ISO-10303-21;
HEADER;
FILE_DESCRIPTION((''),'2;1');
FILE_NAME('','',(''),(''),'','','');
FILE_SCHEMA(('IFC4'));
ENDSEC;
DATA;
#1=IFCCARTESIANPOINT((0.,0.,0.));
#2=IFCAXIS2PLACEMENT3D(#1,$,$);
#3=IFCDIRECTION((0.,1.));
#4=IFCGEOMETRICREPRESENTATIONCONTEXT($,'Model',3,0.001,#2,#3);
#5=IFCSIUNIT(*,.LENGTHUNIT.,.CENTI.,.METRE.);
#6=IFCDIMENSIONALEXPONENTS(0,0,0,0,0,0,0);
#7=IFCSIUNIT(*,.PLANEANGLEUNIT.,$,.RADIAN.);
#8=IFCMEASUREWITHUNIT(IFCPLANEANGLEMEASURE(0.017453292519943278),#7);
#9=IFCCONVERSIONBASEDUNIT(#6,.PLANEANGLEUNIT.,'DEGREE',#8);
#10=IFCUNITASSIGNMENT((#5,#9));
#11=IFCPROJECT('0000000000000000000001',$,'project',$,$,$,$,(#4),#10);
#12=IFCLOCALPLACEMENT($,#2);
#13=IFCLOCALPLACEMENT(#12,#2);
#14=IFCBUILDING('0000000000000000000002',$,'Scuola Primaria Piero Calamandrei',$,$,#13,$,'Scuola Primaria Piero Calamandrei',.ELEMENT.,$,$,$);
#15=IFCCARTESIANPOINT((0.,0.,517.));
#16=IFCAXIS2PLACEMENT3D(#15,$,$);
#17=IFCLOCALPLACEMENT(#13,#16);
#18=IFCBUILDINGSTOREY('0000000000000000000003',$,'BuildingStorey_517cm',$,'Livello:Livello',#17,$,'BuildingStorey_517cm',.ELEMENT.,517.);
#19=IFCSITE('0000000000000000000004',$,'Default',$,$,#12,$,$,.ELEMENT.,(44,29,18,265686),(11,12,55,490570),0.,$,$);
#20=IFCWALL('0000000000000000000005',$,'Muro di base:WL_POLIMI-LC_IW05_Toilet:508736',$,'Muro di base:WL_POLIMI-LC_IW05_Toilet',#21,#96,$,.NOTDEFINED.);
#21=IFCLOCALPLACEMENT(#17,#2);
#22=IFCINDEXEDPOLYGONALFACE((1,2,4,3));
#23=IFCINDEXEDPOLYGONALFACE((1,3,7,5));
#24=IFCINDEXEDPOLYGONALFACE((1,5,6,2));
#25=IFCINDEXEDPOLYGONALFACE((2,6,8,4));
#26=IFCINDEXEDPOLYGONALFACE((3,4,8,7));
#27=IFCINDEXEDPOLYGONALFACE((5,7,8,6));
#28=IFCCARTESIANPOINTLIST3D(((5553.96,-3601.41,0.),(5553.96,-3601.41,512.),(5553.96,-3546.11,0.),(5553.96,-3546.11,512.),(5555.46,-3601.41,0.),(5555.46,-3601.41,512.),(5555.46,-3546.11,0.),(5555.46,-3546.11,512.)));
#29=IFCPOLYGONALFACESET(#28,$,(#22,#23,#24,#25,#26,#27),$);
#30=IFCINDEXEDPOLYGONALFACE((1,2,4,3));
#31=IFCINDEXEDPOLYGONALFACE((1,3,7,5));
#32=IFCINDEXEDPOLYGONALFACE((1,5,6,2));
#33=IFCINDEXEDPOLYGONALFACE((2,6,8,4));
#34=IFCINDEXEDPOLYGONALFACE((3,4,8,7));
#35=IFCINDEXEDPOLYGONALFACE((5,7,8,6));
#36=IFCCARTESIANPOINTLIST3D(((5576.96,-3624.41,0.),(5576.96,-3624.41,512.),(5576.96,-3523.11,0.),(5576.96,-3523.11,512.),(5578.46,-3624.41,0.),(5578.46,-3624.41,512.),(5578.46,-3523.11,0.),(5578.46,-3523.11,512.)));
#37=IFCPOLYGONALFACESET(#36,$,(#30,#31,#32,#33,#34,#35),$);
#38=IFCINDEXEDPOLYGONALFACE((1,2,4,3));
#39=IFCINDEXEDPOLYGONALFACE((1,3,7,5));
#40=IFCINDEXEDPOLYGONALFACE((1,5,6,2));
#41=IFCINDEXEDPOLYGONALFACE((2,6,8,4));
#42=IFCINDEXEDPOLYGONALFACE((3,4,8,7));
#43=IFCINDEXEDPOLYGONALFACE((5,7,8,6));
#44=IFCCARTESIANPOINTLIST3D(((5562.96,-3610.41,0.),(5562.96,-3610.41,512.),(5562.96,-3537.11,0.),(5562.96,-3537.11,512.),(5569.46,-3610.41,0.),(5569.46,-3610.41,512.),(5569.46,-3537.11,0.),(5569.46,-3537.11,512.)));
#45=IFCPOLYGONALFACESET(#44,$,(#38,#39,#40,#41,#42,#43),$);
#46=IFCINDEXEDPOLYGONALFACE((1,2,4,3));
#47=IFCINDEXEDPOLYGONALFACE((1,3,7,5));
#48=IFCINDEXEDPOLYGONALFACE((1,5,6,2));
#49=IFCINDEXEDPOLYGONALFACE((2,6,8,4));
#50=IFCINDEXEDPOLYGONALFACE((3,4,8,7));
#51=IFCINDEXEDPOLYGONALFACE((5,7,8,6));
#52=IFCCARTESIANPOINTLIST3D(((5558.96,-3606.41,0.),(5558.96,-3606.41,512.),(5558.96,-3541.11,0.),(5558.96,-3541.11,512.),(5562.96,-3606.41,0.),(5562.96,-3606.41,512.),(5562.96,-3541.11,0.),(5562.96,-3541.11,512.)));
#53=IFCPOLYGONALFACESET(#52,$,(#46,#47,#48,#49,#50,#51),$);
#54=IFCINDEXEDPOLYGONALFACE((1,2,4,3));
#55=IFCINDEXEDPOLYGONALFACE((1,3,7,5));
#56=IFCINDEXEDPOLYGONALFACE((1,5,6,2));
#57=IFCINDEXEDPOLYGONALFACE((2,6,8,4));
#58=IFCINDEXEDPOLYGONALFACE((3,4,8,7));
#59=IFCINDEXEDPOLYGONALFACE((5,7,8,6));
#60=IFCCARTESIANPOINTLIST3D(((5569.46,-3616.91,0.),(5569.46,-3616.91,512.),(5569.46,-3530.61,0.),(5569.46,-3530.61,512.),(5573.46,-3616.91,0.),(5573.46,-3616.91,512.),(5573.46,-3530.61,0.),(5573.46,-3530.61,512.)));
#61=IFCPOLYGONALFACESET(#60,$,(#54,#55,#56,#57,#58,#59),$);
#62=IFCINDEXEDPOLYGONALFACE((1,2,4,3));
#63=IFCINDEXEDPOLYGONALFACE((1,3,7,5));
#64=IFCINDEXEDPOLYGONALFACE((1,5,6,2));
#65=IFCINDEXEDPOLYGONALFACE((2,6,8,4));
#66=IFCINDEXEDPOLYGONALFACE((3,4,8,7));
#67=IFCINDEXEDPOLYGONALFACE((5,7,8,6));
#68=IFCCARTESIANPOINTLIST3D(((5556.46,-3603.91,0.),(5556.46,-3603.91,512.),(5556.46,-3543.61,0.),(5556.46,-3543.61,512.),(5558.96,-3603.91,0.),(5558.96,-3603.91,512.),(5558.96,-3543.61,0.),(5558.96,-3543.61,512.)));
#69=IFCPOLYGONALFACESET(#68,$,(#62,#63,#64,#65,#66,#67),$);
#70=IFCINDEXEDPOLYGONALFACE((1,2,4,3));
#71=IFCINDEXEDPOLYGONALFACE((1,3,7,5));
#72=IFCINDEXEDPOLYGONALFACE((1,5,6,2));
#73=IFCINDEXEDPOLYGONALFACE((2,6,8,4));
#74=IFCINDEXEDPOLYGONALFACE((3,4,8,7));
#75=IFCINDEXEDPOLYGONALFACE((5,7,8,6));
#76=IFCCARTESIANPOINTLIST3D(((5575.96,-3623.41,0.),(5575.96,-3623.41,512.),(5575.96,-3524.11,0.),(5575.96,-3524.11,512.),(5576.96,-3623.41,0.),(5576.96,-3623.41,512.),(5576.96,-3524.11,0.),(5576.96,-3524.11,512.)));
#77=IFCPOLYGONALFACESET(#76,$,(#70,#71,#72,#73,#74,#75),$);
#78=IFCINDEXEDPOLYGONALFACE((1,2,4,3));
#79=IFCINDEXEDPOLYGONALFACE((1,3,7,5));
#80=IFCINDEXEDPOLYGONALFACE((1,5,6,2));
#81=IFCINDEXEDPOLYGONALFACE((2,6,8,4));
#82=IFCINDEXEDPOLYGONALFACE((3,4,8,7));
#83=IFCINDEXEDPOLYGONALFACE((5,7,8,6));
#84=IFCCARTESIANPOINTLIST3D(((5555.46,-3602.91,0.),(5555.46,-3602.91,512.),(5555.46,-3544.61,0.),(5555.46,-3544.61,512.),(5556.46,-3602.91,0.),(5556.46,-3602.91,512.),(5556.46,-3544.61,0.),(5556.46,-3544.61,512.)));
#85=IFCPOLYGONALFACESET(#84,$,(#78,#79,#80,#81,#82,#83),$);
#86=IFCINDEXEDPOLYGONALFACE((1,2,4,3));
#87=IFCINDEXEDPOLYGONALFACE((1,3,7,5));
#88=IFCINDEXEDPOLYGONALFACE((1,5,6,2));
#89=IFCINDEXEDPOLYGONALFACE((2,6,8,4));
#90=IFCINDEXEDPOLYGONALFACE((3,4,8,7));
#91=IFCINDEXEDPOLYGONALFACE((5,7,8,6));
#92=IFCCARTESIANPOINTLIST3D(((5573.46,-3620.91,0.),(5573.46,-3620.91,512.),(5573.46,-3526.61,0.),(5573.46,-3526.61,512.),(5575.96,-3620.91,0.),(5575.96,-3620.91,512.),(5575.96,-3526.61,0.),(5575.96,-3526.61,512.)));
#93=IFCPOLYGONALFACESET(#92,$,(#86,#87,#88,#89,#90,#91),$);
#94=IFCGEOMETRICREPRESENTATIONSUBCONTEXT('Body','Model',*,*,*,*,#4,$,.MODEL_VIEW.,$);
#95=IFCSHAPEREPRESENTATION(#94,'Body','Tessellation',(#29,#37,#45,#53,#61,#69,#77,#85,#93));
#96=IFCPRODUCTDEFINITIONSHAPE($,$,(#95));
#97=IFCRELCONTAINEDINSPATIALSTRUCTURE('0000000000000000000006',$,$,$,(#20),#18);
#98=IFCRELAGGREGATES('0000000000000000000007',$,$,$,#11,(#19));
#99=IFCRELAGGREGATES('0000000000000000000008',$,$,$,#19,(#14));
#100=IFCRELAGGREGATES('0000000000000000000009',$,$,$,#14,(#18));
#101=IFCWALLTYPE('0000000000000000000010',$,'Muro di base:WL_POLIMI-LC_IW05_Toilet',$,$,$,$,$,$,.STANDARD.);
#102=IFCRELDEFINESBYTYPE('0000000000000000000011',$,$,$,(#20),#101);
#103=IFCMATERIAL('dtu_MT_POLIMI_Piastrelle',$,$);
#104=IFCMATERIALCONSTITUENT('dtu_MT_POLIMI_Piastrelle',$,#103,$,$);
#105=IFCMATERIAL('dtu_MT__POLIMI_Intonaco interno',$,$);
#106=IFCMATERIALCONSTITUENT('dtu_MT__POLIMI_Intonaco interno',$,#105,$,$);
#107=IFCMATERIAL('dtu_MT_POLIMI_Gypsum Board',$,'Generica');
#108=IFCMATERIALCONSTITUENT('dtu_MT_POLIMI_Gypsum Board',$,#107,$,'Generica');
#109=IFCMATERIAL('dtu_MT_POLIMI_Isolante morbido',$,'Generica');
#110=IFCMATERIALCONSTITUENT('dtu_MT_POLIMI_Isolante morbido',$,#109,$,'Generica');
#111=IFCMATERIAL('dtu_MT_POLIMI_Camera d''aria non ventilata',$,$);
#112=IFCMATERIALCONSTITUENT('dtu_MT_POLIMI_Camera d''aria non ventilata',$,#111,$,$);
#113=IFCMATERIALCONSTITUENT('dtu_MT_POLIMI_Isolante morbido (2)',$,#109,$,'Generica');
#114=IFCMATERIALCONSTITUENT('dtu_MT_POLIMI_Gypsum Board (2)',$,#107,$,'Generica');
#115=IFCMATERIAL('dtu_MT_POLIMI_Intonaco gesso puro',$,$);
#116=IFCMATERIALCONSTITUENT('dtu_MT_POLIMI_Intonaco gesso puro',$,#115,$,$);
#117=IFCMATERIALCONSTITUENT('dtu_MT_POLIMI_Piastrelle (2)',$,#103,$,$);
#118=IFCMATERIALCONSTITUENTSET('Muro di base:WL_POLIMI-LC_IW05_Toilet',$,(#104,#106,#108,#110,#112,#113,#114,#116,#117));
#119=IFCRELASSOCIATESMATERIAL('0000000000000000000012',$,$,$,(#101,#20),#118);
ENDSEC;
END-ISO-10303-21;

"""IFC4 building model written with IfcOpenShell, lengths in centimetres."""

from ifc_helpers import new_model, entity, si_unit, converted_unit, direction, frame, origin, place, context, subcontext, project, spatial, indexed_curve, outline, extrude, material, constituent, constituent_set, type_object, element, save


model = new_model("IFC4")

# Units and contexts
model_context = context("Model", 3, precision=0.001, world=origin(), true_north=direction((0.0, 1.0)))
body_context = subcontext(model_context, "Body", "Model", "MODEL_VIEW")
ifc_project = project(units=[si_unit("LENGTHUNIT", "METRE", prefix="CENTI"), converted_unit("PLANEANGLEUNIT", "DEGREE", entity("IfcPlaneAngleMeasure", 0.017453292519943278), si_unit("PLANEANGLEUNIT", "RADIAN"), dimensions=[0, 0, 0, 0, 0, 0, 0])], contexts=[model_context])

# Site, building, storey
site_placement = place(None, origin())
site = spatial("IfcSite", under=ifc_project, at=site_placement, Name="Default", CompositionType="ELEMENT", RefLatitude=(44, 29, 18, 265686), RefLongitude=(11, 12, 55, 490570), RefElevation=0.0)
building_placement = place(site_placement, origin())
building = spatial("IfcBuilding", under=site, at=building_placement, Name="Scuola Primaria Piero Calamandrei", LongName="Scuola Primaria Piero Calamandrei", CompositionType="ELEMENT")
storey_placement = place(building_placement, frame((0.0, 0.0, 517.0)))
storey = spatial("IfcBuildingStorey", under=building, at=storey_placement, Name="BuildingStorey_517cm", ObjectType="Livello:Livello", LongName="BuildingStorey_517cm", CompositionType="ELEMENT", Elevation=517.0)

# Shared definitions
ifc_material_1 = material(Name="dtu_MT_POLIMI_Isolante morbido", Category="Generica")
ifc_material_2 = material(Name="dtu_MT_POLIMI_Gypsum Board", Category="Generica")
ifc_material_3 = material(Name="dtu_MT__POLIMI_Intonaco interno")

# Shared definitions
ifc_material_4 = material(Name="dtu_MT_POLIMI_Camera d'aria non ventilata")
ifc_material_5 = material(Name="dtu_MT_POLIMI_Intonaco gesso puro")

# Wall
ifc_material_6 = material(Name="dtu_MT_POLIMI_Piastrelle")
ifc_constituent_1 = constituent(ifc_material_6, Name="dtu_MT_POLIMI_Piastrelle")
ifc_constituent_2 = constituent(ifc_material_3, Name="dtu_MT__POLIMI_Intonaco interno")
ifc_constituent_3 = constituent(ifc_material_2, Name="dtu_MT_POLIMI_Gypsum Board", Category="Generica")
ifc_constituent_4 = constituent(ifc_material_1, Name="dtu_MT_POLIMI_Isolante morbido", Category="Generica")
ifc_constituent_5 = constituent(ifc_material_4, Name="dtu_MT_POLIMI_Camera d'aria non ventilata")
ifc_constituent_6 = constituent(ifc_material_1, Name="dtu_MT_POLIMI_Isolante morbido (2)", Category="Generica")
ifc_constituent_7 = constituent(ifc_material_2, Name="dtu_MT_POLIMI_Gypsum Board (2)", Category="Generica")
ifc_constituent_8 = constituent(ifc_material_5, Name="dtu_MT_POLIMI_Intonaco gesso puro")
ifc_constituent_9 = constituent(ifc_material_6, Name="dtu_MT_POLIMI_Piastrelle (2)")
ifc_constituent_set_1 = constituent_set(constituents=[ifc_constituent_1, ifc_constituent_2, ifc_constituent_3, ifc_constituent_4, ifc_constituent_5, ifc_constituent_6, ifc_constituent_7, ifc_constituent_8, ifc_constituent_9], Name="Muro di base:WL_POLIMI-LC_IW05_Toilet")
wall_type_1 = type_object("IfcWallType", Name="Muro di base:WL_POLIMI-LC_IW05_Toilet", PredefinedType="STANDARD", material=ifc_constituent_set_1)
wall_1_placement = place(storey_placement, frame((5566.21, -3601.41, 0.0), z_axis=(0.0, 0.0, 1.0), x_axis=(0.0, 1.0, 0.0)))
element("IfcWall", 1, at=wall_1_placement, inside=storey, type_object=wall_type_1, material=ifc_constituent_set_1, Name="Muro di base:WL_POLIMI-LC_IW05_Toilet:508736", ObjectType="Muro di base:WL_POLIMI-LC_IW05_Toilet", PredefinedType="NOTDEFINED", context=body_context, shape_type="SweptSolid", body=[
    extrude(outline(indexed_curve([(-0.75, -27.65), (0.75, -27.65), (0.75, 27.65), (-0.75, 27.65), (-0.75, -27.65)], self_intersect=False)), frame((27.65, 11.5, 0.0), z_axis=(0.0, 0.0, 1.0), x_axis=(0.0, -1.0, 0.0)), (0.0, 0.0, 1.0), 512.0),
    extrude(outline(indexed_curve([(-0.75, -50.65), (0.75, -50.65), (0.75, 50.65), (-0.75, 50.65), (-0.75, -50.65)], self_intersect=False)), frame((27.65, -11.5, 0.0), z_axis=(0.0, 0.0, 1.0), x_axis=(0.0, 1.0, 0.0)), (0.0, 0.0, 1.0), 512.0),
    extrude(outline(indexed_curve([(-36.65, -3.25), (36.65, -3.25), (36.65, 3.25), (-36.65, 3.25), (-36.65, -3.25)], self_intersect=False)), frame((27.65, 0.0, 0.0)), (0.0, 0.0, 1.0), 512.0),
    extrude(outline(indexed_curve([(-32.65, -2.0), (32.65, -2.0), (32.65, 2.0), (-32.65, 2.0), (-32.65, -2.0)], self_intersect=False)), frame((27.65, 5.25, 0.0)), (0.0, 0.0, 1.0), 512.0),
    extrude(outline(indexed_curve([(-43.15, -2.0), (43.15, -2.0), (43.15, 2.0), (-43.15, 2.0), (-43.15, -2.0)], self_intersect=False)), frame((27.65, -5.25, 0.0)), (0.0, 0.0, 1.0), 512.0),
    extrude(outline(indexed_curve([(-30.15, -1.25), (30.15, -1.25), (30.15, 1.25), (-30.15, 1.25), (-30.15, -1.25)], self_intersect=False)), frame((27.65, 8.5, 0.0)), (0.0, 0.0, 1.0), 512.0),
    extrude(outline(indexed_curve([(-49.65, -0.5), (49.65, -0.5), (49.65, 0.5), (-49.65, 0.5), (-49.65, -0.5)], self_intersect=False)), frame((27.65, -10.25, 0.0)), (0.0, 0.0, 1.0), 512.0),
    extrude(outline(indexed_curve([(-29.15, -0.5), (29.15, -0.5), (29.15, 0.5), (-29.15, 0.5), (-29.15, -0.5)], self_intersect=False)), frame((27.65, 10.25, 0.0)), (0.0, 0.0, 1.0), 512.0),
    extrude(outline(indexed_curve([(-47.15, -1.25), (47.15, -1.25), (47.15, 1.25), (-47.15, 1.25), (-47.15, -1.25)], self_intersect=False)), frame((27.65, -8.5, 0.0)), (0.0, 0.0, 1.0), 512.0),
])

save(model, "model.ifc")
